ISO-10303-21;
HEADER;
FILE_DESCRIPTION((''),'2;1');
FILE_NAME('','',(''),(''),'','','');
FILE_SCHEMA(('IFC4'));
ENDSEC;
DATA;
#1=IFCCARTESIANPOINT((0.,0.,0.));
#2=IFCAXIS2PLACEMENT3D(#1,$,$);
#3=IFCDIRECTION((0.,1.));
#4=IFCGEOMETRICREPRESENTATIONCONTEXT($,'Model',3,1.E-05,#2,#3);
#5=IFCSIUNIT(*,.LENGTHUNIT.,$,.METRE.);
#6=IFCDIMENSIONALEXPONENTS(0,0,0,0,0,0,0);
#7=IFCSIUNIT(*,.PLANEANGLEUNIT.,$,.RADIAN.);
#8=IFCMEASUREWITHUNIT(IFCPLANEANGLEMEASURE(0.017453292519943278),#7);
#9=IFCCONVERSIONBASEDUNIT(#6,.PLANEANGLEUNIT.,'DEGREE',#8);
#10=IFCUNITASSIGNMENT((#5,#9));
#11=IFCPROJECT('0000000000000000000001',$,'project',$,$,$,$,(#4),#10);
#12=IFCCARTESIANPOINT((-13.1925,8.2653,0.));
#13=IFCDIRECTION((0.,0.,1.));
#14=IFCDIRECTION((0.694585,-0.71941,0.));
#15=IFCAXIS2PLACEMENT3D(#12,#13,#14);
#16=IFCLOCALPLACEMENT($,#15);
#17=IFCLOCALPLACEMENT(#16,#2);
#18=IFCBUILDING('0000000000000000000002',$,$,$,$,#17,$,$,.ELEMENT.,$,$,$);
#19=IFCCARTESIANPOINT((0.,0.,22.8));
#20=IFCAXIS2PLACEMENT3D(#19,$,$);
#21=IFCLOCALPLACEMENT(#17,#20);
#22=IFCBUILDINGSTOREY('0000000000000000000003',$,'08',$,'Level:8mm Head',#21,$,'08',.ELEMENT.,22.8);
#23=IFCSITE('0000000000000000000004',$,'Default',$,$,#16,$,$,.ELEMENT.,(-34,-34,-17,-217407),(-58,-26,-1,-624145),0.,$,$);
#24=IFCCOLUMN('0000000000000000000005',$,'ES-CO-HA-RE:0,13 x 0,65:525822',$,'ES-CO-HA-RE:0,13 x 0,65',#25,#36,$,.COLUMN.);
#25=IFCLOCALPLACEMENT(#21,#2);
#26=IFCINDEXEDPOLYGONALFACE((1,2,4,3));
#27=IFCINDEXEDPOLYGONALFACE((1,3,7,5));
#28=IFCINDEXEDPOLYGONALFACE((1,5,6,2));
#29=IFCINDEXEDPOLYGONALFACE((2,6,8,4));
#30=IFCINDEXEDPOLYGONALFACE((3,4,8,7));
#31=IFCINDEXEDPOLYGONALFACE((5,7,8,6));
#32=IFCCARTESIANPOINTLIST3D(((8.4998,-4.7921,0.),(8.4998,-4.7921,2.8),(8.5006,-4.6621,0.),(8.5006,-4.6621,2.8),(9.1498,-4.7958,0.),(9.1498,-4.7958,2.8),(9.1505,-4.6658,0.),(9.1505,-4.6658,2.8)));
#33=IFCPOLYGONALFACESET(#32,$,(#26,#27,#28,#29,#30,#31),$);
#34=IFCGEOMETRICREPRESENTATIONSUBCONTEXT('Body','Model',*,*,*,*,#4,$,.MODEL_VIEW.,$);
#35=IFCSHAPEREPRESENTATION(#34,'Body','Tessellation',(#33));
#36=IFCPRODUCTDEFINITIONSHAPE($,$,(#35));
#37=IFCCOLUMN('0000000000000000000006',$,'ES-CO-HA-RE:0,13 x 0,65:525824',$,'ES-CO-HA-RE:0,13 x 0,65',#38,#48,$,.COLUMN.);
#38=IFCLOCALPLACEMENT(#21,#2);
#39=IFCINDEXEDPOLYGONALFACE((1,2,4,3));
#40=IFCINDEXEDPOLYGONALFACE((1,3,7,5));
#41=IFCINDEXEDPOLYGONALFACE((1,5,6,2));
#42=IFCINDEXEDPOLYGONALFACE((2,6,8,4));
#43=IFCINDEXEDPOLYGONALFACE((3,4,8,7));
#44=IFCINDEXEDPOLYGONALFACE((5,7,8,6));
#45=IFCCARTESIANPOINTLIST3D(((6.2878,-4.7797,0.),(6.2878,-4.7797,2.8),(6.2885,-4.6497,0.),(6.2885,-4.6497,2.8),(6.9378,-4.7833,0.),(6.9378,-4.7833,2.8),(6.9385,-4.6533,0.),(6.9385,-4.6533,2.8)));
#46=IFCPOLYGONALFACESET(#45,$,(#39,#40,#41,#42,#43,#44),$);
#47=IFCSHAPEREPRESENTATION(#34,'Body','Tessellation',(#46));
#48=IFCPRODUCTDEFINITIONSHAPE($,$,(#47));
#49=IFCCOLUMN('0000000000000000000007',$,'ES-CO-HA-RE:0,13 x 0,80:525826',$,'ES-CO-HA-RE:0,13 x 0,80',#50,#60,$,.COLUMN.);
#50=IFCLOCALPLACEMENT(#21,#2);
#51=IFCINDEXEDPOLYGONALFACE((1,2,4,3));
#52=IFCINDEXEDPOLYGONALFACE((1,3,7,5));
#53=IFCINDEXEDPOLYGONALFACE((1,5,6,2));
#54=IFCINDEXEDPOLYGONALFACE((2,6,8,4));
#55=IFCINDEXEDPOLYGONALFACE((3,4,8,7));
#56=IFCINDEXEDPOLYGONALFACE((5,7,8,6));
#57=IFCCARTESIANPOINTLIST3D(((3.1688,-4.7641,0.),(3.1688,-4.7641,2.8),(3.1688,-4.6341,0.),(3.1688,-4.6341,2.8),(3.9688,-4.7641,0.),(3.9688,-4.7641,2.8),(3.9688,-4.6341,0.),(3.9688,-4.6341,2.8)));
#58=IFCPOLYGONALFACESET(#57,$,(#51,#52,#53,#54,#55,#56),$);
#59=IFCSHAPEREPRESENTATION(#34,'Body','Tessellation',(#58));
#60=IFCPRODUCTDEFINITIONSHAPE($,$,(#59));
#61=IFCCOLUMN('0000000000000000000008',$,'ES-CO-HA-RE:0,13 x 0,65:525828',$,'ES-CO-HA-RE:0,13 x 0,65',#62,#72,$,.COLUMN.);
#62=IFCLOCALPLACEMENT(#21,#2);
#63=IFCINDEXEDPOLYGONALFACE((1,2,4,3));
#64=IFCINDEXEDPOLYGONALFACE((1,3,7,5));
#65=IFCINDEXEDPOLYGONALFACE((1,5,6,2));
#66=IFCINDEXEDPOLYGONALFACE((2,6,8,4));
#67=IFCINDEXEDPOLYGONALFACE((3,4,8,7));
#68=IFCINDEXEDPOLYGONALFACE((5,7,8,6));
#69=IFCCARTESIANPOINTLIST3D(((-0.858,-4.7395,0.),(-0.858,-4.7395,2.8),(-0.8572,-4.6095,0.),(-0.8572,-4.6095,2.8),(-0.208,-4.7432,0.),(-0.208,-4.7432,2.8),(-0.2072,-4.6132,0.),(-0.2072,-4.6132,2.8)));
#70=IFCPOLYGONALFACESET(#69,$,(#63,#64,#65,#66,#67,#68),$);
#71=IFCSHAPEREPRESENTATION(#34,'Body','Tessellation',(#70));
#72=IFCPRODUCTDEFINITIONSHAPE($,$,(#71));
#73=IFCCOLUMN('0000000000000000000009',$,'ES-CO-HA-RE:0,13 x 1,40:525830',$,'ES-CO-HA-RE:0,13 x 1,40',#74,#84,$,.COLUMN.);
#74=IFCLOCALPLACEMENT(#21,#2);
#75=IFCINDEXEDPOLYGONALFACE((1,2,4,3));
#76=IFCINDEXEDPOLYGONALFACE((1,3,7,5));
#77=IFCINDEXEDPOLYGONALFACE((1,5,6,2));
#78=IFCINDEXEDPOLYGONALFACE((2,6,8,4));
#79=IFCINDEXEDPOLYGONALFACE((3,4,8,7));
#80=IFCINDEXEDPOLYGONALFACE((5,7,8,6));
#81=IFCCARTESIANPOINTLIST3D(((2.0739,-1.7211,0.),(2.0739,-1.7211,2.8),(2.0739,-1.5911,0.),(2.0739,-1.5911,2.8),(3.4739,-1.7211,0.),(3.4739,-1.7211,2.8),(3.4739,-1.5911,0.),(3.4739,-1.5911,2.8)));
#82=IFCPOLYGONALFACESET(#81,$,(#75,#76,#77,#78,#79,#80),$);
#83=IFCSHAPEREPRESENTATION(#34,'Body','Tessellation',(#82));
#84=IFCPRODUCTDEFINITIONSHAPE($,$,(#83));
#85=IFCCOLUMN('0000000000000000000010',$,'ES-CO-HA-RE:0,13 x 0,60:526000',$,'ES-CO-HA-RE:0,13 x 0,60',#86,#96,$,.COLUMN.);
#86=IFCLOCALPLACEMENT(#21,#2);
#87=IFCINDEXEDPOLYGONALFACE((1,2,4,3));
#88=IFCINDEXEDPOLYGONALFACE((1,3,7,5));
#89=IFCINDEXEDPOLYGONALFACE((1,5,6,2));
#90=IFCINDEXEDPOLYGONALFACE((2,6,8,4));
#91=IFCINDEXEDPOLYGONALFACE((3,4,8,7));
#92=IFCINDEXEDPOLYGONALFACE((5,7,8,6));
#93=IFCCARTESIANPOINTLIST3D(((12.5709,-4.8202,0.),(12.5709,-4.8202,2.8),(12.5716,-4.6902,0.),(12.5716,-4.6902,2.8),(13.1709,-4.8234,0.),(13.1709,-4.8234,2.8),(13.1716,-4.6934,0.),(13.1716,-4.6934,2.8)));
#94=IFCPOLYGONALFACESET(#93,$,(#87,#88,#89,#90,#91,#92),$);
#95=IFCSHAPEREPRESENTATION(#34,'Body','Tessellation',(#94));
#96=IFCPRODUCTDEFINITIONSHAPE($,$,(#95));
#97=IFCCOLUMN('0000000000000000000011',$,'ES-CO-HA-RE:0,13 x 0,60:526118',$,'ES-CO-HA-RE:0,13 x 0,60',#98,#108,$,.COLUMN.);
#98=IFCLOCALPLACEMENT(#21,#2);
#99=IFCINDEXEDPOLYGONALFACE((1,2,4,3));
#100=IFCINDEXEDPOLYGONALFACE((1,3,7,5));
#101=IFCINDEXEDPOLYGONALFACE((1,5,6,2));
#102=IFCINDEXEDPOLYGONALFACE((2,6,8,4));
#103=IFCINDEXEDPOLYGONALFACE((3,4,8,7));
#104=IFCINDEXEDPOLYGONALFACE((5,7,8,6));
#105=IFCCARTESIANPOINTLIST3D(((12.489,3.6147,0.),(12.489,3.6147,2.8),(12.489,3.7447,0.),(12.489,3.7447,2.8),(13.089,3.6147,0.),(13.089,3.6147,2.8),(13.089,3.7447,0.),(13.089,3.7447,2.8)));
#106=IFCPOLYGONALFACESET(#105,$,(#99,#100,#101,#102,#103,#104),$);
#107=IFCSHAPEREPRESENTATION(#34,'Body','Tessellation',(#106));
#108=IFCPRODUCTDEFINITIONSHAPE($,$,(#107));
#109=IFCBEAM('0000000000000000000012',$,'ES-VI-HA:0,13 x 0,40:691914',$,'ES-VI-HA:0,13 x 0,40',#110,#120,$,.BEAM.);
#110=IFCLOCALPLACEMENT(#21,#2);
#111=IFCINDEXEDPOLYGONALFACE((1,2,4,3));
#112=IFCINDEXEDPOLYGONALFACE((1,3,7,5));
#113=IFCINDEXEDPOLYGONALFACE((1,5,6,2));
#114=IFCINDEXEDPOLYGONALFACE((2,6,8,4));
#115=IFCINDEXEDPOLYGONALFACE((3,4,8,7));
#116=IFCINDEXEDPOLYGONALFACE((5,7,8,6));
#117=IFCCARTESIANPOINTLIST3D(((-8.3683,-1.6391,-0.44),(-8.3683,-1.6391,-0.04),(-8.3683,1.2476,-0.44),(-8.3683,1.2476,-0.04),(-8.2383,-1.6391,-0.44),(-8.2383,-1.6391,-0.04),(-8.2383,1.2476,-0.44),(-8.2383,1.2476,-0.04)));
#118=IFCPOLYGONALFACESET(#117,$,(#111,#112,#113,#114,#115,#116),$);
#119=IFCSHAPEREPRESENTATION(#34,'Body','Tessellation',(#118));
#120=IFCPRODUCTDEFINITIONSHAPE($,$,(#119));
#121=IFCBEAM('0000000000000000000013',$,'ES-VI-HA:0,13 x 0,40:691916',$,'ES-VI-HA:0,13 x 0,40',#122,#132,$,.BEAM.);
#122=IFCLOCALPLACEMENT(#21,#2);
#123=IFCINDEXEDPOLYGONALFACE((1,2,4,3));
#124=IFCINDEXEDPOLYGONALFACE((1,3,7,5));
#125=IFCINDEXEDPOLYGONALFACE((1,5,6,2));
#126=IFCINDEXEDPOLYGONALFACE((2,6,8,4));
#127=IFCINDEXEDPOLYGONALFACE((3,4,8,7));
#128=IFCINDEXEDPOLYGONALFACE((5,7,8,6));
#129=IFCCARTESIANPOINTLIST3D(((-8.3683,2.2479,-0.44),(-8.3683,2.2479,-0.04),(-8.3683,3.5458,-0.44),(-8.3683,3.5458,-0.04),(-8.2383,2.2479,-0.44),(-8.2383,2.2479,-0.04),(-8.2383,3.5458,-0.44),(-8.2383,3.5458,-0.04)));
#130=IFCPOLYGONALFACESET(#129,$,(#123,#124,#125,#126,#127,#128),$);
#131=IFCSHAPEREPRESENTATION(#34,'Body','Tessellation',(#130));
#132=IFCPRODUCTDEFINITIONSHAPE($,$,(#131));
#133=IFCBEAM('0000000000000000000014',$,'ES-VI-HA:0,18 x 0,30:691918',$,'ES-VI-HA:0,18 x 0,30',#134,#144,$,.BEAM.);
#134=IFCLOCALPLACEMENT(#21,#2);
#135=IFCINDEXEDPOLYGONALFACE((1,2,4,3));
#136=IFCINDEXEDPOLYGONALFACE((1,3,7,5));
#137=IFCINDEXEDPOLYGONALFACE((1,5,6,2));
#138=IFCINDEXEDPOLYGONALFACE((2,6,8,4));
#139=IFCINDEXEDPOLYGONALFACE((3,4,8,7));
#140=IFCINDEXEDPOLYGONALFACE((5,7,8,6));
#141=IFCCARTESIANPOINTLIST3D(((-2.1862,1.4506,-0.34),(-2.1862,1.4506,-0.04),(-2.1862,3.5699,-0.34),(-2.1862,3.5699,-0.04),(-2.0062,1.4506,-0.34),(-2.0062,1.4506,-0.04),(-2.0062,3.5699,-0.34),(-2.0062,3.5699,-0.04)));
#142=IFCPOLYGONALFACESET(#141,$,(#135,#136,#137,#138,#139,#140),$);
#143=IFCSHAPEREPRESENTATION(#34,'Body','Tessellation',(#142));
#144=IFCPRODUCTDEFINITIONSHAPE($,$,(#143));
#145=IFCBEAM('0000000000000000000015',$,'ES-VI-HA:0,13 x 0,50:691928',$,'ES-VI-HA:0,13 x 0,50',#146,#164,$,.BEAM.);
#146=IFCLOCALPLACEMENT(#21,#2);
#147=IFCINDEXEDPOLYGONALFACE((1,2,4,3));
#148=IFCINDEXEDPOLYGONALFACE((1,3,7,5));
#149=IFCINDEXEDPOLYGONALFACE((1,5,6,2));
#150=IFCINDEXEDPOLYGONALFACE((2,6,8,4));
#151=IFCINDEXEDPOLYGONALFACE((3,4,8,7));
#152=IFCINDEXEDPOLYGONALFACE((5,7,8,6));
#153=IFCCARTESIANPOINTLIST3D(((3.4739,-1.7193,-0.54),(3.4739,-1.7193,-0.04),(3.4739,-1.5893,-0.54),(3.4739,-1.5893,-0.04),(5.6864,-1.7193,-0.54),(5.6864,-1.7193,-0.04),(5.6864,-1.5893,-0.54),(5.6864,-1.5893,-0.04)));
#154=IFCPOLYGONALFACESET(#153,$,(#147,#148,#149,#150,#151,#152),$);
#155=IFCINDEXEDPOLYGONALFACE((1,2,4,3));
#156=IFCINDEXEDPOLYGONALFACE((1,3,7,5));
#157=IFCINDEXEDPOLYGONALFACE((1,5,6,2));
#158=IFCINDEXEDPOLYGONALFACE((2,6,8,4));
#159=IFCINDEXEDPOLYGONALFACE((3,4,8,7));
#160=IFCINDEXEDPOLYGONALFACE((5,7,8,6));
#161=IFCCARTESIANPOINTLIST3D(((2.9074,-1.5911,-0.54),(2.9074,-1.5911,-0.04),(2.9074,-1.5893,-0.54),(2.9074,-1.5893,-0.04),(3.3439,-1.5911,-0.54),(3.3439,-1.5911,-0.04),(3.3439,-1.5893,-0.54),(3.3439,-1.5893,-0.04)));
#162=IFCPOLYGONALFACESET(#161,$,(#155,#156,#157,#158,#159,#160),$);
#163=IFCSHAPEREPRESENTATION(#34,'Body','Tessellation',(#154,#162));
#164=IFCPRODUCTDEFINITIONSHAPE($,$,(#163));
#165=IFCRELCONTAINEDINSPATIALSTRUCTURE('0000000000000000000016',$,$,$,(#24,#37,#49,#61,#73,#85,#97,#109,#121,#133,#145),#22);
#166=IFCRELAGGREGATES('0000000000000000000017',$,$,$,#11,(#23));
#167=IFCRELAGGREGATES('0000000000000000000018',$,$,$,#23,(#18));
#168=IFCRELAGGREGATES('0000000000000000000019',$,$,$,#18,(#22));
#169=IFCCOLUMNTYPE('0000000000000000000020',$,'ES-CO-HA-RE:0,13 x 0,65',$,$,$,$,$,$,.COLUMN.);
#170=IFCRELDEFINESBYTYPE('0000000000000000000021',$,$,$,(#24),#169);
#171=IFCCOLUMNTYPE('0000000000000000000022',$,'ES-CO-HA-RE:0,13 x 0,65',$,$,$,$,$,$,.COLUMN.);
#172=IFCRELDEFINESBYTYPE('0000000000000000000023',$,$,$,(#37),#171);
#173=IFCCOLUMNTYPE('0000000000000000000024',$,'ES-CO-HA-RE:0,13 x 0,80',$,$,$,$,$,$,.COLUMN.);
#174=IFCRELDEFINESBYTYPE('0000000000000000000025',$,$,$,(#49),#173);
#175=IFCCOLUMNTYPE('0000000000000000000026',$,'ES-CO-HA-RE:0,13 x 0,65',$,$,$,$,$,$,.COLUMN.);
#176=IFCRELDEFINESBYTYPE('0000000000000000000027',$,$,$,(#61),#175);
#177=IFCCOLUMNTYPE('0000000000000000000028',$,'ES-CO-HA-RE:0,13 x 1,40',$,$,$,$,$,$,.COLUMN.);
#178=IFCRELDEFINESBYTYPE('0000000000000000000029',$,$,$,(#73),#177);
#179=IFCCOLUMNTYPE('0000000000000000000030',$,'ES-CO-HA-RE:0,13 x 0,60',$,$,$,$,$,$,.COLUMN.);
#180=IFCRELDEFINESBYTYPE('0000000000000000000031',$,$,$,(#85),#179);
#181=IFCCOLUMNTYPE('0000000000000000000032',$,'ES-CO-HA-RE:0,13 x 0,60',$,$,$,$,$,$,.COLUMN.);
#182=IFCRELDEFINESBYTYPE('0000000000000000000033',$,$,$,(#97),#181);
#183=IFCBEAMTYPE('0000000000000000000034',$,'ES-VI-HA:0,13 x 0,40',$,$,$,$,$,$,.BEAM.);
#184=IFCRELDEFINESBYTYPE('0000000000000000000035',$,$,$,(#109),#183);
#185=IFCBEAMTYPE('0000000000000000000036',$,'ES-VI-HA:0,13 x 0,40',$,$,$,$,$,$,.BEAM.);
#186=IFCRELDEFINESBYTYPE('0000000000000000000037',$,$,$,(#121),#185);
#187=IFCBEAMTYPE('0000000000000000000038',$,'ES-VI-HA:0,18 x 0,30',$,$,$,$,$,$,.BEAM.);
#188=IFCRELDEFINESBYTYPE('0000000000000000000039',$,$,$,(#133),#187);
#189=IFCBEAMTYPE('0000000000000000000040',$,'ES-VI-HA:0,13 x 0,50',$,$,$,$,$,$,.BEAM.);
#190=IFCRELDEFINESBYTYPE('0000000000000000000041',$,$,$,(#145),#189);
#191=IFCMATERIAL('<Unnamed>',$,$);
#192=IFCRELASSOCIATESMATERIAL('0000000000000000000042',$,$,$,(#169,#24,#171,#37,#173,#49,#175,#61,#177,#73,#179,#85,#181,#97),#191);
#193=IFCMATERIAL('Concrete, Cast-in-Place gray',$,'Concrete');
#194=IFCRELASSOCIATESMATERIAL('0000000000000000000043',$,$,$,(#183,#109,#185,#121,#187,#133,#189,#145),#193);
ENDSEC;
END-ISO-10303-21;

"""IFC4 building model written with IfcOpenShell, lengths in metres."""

from ifc_helpers import new_model, entity, si_unit, converted_unit, direction, frame, origin, place, context, subcontext, project, spatial, indexed_curve, outline, extrude, source, transform, mapped, material, type_object, type_shapes, element, save


model = new_model("IFC4")

# Units and contexts
model_context = context("Model", 3, precision=1e-05, world=origin(), true_north=direction((0.0, 1.0)))
body_context = subcontext(model_context, "Body", "Model", "MODEL_VIEW")
ifc_project = project(units=[si_unit("LENGTHUNIT", "METRE"), converted_unit("PLANEANGLEUNIT", "DEGREE", entity("IfcPlaneAngleMeasure", 0.017453292519943278), si_unit("PLANEANGLEUNIT", "RADIAN"), dimensions=[0, 0, 0, 0, 0, 0, 0])], contexts=[model_context])

# Site, building, storey
site_placement = place(None, frame((-13.1925, 8.2653, 0.0), z_axis=(0.0, 0.0, 1.0), x_axis=(0.694585, -0.71941, 0.0)))
site = spatial("IfcSite", under=ifc_project, at=site_placement, Name="Default", CompositionType="ELEMENT", RefLatitude=(-34, -34, -17, -217407), RefLongitude=(-58, -26, -1, -624145), RefElevation=0.0)
building_placement = place(site_placement, origin())
building = spatial("IfcBuilding", under=site, at=building_placement, CompositionType="ELEMENT")
storey_placement = place(building_placement, frame((0.0, 0.0, 22.8)))
storey = spatial("IfcBuildingStorey", under=building, at=storey_placement, Name="08", ObjectType="Level:8mm Head", LongName="08", CompositionType="ELEMENT", Elevation=22.8)

# Columns
ifc_material_1 = material(Name="<Unnamed>")
column_type_1 = type_object("IfcColumnType", Name="ES-CO-HA-RE:0,13 x 0,65", PredefinedType="COLUMN", material=ifc_material_1)
shared_shape_1 = source(origin(), body_context, "Body", "SweptSolid", [
    extrude(outline(indexed_curve([(-0.325, -0.065), (0.325, -0.065), (0.325, 0.065), (-0.325, 0.065), (-0.325, -0.065)], self_intersect=False)), frame((8.8252, -4.7289, 22.8), z_axis=(0.0, 0.0, 1.0), x_axis=(-0.999984, 0.005619, 0.0)), (0.0, 0.0, 1.0), 2.8),
])
type_shapes(column_type_1, [shared_shape_1])
column_1_placement = place(storey_placement, frame((0.0, 0.0, -22.8)))
element("IfcColumn", 1, at=column_1_placement, inside=storey, type_object=column_type_1, material=ifc_material_1, Name="ES-CO-HA-RE:0,13 x 0,65:525822", ObjectType="ES-CO-HA-RE:0,13 x 0,65", PredefinedType="COLUMN", context=body_context, shape_type="MappedRepresentation", body=[
    mapped(shared_shape_1, transform((0.0, 0.0, 0.0), scale=1.0)),
])
column_type_2 = type_object("IfcColumnType", Name="ES-CO-HA-RE:0,13 x 0,65", PredefinedType="COLUMN", material=ifc_material_1)
shared_shape_2 = source(origin(), body_context, "Body", "SweptSolid", [
    extrude(outline(indexed_curve([(-0.325, -0.065), (0.325, -0.065), (0.325, 0.065), (-0.325, 0.065), (-0.325, -0.065)], self_intersect=False)), frame((6.6131, -4.7165, 22.8), z_axis=(0.0, 0.0, 1.0), x_axis=(-0.999984, 0.005619, 0.0)), (0.0, 0.0, 1.0), 2.8),
])
type_shapes(column_type_2, [shared_shape_2])
column_2_placement = place(storey_placement, frame((0.0, 0.0, -22.8)))
element("IfcColumn", 2, at=column_2_placement, inside=storey, type_object=column_type_2, material=ifc_material_1, Name="ES-CO-HA-RE:0,13 x 0,65:525824", ObjectType="ES-CO-HA-RE:0,13 x 0,65", PredefinedType="COLUMN", context=body_context, shape_type="MappedRepresentation", body=[
    mapped(shared_shape_2, transform((0.0, 0.0, 0.0), scale=1.0)),
])
column_type_3 = type_object("IfcColumnType", Name="ES-CO-HA-RE:0,13 x 0,80", PredefinedType="COLUMN", material=ifc_material_1)
shared_shape_3 = source(origin(), body_context, "Body", "SweptSolid", [
    extrude(outline(indexed_curve([(-0.4, -0.065), (0.4, -0.065), (0.4, 0.065), (-0.4, 0.065), (-0.4, -0.065)], self_intersect=False)), frame((3.5688, -4.6991, 22.8), z_axis=(0.0, 0.0, 1.0), x_axis=(-1.0, 0.0, 0.0)), (0.0, 0.0, 1.0), 2.8),
])
type_shapes(column_type_3, [shared_shape_3])
column_3_placement = place(storey_placement, frame((0.0, 0.0, -22.8)))
element("IfcColumn", 3, at=column_3_placement, inside=storey, type_object=column_type_3, material=ifc_material_1, Name="ES-CO-HA-RE:0,13 x 0,80:525826", ObjectType="ES-CO-HA-RE:0,13 x 0,80", PredefinedType="COLUMN", context=body_context, shape_type="MappedRepresentation", body=[
    mapped(shared_shape_3, transform((0.0, 0.0, 0.0), scale=1.0)),
])
column_type_4 = type_object("IfcColumnType", Name="ES-CO-HA-RE:0,13 x 0,65", PredefinedType="COLUMN", material=ifc_material_1)
shared_shape_4 = source(origin(), body_context, "Body", "SweptSolid", [
    extrude(outline(indexed_curve([(-0.325, -0.065), (0.325, -0.065), (0.325, 0.065), (-0.325, 0.065), (-0.325, -0.065)], self_intersect=False)), frame((-0.5326, -4.6764, 22.8), z_axis=(0.0, 0.0, 1.0), x_axis=(-0.999984, 0.005619, 0.0)), (0.0, 0.0, 1.0), 2.8),
])
type_shapes(column_type_4, [shared_shape_4])
column_4_placement = place(storey_placement, frame((0.0, 0.0, -22.8)))
element("IfcColumn", 4, at=column_4_placement, inside=storey, type_object=column_type_4, material=ifc_material_1, Name="ES-CO-HA-RE:0,13 x 0,65:525828", ObjectType="ES-CO-HA-RE:0,13 x 0,65", PredefinedType="COLUMN", context=body_context, shape_type="MappedRepresentation", body=[
    mapped(shared_shape_4, transform((0.0, 0.0, 0.0), scale=1.0)),
])
column_type_5 = type_object("IfcColumnType", Name="ES-CO-HA-RE:0,13 x 1,40", PredefinedType="COLUMN", material=ifc_material_1)
shared_shape_5 = source(origin(), body_context, "Body", "SweptSolid", [
    extrude(outline(indexed_curve([(-0.7, -0.065), (0.7, -0.065), (0.7, 0.065), (-0.7, 0.065), (-0.7, -0.065)], self_intersect=False)), frame((2.7739, -1.6561, 22.8), z_axis=(0.0, 0.0, 1.0), x_axis=(-1.0, 0.0, 0.0)), (0.0, 0.0, 1.0), 2.8),
])
type_shapes(column_type_5, [shared_shape_5])
column_5_placement = place(storey_placement, frame((0.0, 0.0, -22.8)))
element("IfcColumn", 5, at=column_5_placement, inside=storey, type_object=column_type_5, material=ifc_material_1, Name="ES-CO-HA-RE:0,13 x 1,40:525830", ObjectType="ES-CO-HA-RE:0,13 x 1,40", PredefinedType="COLUMN", context=body_context, shape_type="MappedRepresentation", body=[
    mapped(shared_shape_5, transform((0.0, 0.0, 0.0), scale=1.0)),
])
column_type_6 = type_object("IfcColumnType", Name="ES-CO-HA-RE:0,13 x 0,60", PredefinedType="COLUMN", material=ifc_material_1)
shared_shape_6 = source(origin(), body_context, "Body", "SweptSolid", [
    extrude(outline(indexed_curve([(-0.3, -0.065), (0.3, -0.065), (0.3, 0.065), (-0.3, 0.065), (-0.3, -0.065)], self_intersect=False)), frame((12.8713, -4.7568, 22.8), z_axis=(0.0, 0.0, 1.0), x_axis=(-0.999985, 0.005426, 0.0)), (0.0, 0.0, 1.0), 2.8),
])
type_shapes(column_type_6, [shared_shape_6])
column_6_placement = place(storey_placement, frame((0.0, 0.0, -22.8)))
element("IfcColumn", 6, at=column_6_placement, inside=storey, type_object=column_type_6, material=ifc_material_1, Name="ES-CO-HA-RE:0,13 x 0,60:526000", ObjectType="ES-CO-HA-RE:0,13 x 0,60", PredefinedType="COLUMN", context=body_context, shape_type="MappedRepresentation", body=[
    mapped(shared_shape_6, transform((0.0, 0.0, 0.0), scale=1.0)),
])
column_type_7 = type_object("IfcColumnType", Name="ES-CO-HA-RE:0,13 x 0,60", PredefinedType="COLUMN", material=ifc_material_1)
shared_shape_7 = source(origin(), body_context, "Body", "SweptSolid", [
    extrude(outline(indexed_curve([(-0.3, -0.065), (0.3, -0.065), (0.3, 0.065), (-0.3, 0.065), (-0.3, -0.065)], self_intersect=False)), frame((12.789, 3.6797, 22.8), z_axis=(0.0, 0.0, 1.0), x_axis=(-1.0, 0.0, 0.0)), (0.0, 0.0, 1.0), 2.8),
])
type_shapes(column_type_7, [shared_shape_7])
column_7_placement = place(storey_placement, frame((0.0, 0.0, -22.8)))
element("IfcColumn", 7, at=column_7_placement, inside=storey, type_object=column_type_7, material=ifc_material_1, Name="ES-CO-HA-RE:0,13 x 0,60:526118", ObjectType="ES-CO-HA-RE:0,13 x 0,60", PredefinedType="COLUMN", context=body_context, shape_type="MappedRepresentation", body=[
    mapped(shared_shape_7, transform((0.0, 0.0, 0.0), scale=1.0)),
])

# Beams
ifc_material_2 = material(Name="Concrete, Cast-in-Place gray", Category="Concrete")
beam_type_1 = type_object("IfcBeamType", Name="ES-VI-HA:0,13 x 0,40", PredefinedType="BEAM", material=ifc_material_2)
shared_shape_8 = source(origin(), body_context, "Body", "SweptSolid", [
    extrude(outline(indexed_curve([(-0.065, -0.2), (0.065, -0.2), (0.065, 0.2), (-0.065, 0.2), (-0.065, -0.2)], self_intersect=False)), frame((-8.3033, -1.6391, 22.56), z_axis=(0.0, 1.0, 0.0), x_axis=(-1.0, 0.0, 0.0)), (0.0, 0.0, 1.0), 2.8867),
])
type_shapes(beam_type_1, [shared_shape_8])
beam_1_placement = place(storey_placement, frame((0.0, 0.0, -22.8)))
element("IfcBeam", 8, at=beam_1_placement, inside=storey, type_object=beam_type_1, material=ifc_material_2, Name="ES-VI-HA:0,13 x 0,40:691914", ObjectType="ES-VI-HA:0,13 x 0,40", PredefinedType="BEAM", context=body_context, shape_type="MappedRepresentation", body=[
    mapped(shared_shape_8, transform((0.0, 0.0, 0.0), scale=1.0)),
])
beam_type_2 = type_object("IfcBeamType", Name="ES-VI-HA:0,13 x 0,40", PredefinedType="BEAM", material=ifc_material_2)
shared_shape_9 = source(origin(), body_context, "Body", "SweptSolid", [
    extrude(outline(indexed_curve([(-0.065, -0.2), (0.065, -0.2), (0.065, 0.2), (-0.065, 0.2), (-0.065, -0.2)], self_intersect=False)), frame((-8.3033, 2.2479, 22.56), z_axis=(0.0, 1.0, 0.0), x_axis=(-1.0, 0.0, 0.0)), (0.0, 0.0, 1.0), 1.298),
])
type_shapes(beam_type_2, [shared_shape_9])
beam_2_placement = place(storey_placement, frame((0.0, 0.0, -22.8)))
element("IfcBeam", 9, at=beam_2_placement, inside=storey, type_object=beam_type_2, material=ifc_material_2, Name="ES-VI-HA:0,13 x 0,40:691916", ObjectType="ES-VI-HA:0,13 x 0,40", PredefinedType="BEAM", context=body_context, shape_type="MappedRepresentation", body=[
    mapped(shared_shape_9, transform((0.0, 0.0, 0.0), scale=1.0)),
])
beam_type_3 = type_object("IfcBeamType", Name="ES-VI-HA:0,18 x 0,30", PredefinedType="BEAM", material=ifc_material_2)
shared_shape_10 = source(origin(), body_context, "Body", "SweptSolid", [
    extrude(outline(indexed_curve([(-0.09, -0.15), (0.09, -0.15), (0.09, 0.15), (-0.09, 0.15), (-0.09, -0.15)], self_intersect=False)), frame((-2.0962, 3.5699, 22.61), z_axis=(0.0, -1.0, 0.0), x_axis=(-1.0, 0.0, 0.0)), (0.0, 0.0, 1.0), 2.1193),
])
type_shapes(beam_type_3, [shared_shape_10])
beam_3_placement = place(storey_placement, frame((0.0, 0.0, -22.8)))
element("IfcBeam", 10, at=beam_3_placement, inside=storey, type_object=beam_type_3, material=ifc_material_2, Name="ES-VI-HA:0,18 x 0,30:691918", ObjectType="ES-VI-HA:0,18 x 0,30", PredefinedType="BEAM", context=body_context, shape_type="MappedRepresentation", body=[
    mapped(shared_shape_10, transform((0.0, 0.0, 0.0), scale=1.0)),
])
beam_type_4 = type_object("IfcBeamType", Name="ES-VI-HA:0,13 x 0,50", PredefinedType="BEAM", material=ifc_material_2)
shared_shape_11 = source(origin(), body_context, "Body", "SweptSolid", [
    extrude(outline(indexed_curve([(-0.25, -0.065), (0.25, -0.065), (0.25, 0.065), (-0.25, 0.065), (-0.25, -0.065)], self_intersect=False)), frame((3.4739, -1.6543, 22.51), z_axis=(1.0, 0.0, 0.0), x_axis=(0.0, 0.0, -1.0)), (0.0, 0.0, 1.0), 2.2125),
    extrude(outline(indexed_curve([(-0.25, -0.0009), (0.25, -0.0009), (0.25, 0.0009), (-0.25, 0.0009), (-0.25, -0.0009)], self_intersect=False)), frame((2.9074, -1.5902, 22.51), z_axis=(1.0, 0.0, 0.0), x_axis=(0.0, 0.0, -1.0)), (0.0, 0.0, 1.0), 0.4365),
])
type_shapes(beam_type_4, [shared_shape_11])
beam_4_placement = place(storey_placement, frame((0.0, 0.0, -22.8)))
element("IfcBeam", 11, at=beam_4_placement, inside=storey, type_object=beam_type_4, material=ifc_material_2, Name="ES-VI-HA:0,13 x 0,50:691928", ObjectType="ES-VI-HA:0,13 x 0,50", PredefinedType="BEAM", context=body_context, shape_type="MappedRepresentation", body=[
    mapped(shared_shape_11, transform((0.0, 0.0, 0.0), scale=1.0)),
])

save(model, "model.ifc")
